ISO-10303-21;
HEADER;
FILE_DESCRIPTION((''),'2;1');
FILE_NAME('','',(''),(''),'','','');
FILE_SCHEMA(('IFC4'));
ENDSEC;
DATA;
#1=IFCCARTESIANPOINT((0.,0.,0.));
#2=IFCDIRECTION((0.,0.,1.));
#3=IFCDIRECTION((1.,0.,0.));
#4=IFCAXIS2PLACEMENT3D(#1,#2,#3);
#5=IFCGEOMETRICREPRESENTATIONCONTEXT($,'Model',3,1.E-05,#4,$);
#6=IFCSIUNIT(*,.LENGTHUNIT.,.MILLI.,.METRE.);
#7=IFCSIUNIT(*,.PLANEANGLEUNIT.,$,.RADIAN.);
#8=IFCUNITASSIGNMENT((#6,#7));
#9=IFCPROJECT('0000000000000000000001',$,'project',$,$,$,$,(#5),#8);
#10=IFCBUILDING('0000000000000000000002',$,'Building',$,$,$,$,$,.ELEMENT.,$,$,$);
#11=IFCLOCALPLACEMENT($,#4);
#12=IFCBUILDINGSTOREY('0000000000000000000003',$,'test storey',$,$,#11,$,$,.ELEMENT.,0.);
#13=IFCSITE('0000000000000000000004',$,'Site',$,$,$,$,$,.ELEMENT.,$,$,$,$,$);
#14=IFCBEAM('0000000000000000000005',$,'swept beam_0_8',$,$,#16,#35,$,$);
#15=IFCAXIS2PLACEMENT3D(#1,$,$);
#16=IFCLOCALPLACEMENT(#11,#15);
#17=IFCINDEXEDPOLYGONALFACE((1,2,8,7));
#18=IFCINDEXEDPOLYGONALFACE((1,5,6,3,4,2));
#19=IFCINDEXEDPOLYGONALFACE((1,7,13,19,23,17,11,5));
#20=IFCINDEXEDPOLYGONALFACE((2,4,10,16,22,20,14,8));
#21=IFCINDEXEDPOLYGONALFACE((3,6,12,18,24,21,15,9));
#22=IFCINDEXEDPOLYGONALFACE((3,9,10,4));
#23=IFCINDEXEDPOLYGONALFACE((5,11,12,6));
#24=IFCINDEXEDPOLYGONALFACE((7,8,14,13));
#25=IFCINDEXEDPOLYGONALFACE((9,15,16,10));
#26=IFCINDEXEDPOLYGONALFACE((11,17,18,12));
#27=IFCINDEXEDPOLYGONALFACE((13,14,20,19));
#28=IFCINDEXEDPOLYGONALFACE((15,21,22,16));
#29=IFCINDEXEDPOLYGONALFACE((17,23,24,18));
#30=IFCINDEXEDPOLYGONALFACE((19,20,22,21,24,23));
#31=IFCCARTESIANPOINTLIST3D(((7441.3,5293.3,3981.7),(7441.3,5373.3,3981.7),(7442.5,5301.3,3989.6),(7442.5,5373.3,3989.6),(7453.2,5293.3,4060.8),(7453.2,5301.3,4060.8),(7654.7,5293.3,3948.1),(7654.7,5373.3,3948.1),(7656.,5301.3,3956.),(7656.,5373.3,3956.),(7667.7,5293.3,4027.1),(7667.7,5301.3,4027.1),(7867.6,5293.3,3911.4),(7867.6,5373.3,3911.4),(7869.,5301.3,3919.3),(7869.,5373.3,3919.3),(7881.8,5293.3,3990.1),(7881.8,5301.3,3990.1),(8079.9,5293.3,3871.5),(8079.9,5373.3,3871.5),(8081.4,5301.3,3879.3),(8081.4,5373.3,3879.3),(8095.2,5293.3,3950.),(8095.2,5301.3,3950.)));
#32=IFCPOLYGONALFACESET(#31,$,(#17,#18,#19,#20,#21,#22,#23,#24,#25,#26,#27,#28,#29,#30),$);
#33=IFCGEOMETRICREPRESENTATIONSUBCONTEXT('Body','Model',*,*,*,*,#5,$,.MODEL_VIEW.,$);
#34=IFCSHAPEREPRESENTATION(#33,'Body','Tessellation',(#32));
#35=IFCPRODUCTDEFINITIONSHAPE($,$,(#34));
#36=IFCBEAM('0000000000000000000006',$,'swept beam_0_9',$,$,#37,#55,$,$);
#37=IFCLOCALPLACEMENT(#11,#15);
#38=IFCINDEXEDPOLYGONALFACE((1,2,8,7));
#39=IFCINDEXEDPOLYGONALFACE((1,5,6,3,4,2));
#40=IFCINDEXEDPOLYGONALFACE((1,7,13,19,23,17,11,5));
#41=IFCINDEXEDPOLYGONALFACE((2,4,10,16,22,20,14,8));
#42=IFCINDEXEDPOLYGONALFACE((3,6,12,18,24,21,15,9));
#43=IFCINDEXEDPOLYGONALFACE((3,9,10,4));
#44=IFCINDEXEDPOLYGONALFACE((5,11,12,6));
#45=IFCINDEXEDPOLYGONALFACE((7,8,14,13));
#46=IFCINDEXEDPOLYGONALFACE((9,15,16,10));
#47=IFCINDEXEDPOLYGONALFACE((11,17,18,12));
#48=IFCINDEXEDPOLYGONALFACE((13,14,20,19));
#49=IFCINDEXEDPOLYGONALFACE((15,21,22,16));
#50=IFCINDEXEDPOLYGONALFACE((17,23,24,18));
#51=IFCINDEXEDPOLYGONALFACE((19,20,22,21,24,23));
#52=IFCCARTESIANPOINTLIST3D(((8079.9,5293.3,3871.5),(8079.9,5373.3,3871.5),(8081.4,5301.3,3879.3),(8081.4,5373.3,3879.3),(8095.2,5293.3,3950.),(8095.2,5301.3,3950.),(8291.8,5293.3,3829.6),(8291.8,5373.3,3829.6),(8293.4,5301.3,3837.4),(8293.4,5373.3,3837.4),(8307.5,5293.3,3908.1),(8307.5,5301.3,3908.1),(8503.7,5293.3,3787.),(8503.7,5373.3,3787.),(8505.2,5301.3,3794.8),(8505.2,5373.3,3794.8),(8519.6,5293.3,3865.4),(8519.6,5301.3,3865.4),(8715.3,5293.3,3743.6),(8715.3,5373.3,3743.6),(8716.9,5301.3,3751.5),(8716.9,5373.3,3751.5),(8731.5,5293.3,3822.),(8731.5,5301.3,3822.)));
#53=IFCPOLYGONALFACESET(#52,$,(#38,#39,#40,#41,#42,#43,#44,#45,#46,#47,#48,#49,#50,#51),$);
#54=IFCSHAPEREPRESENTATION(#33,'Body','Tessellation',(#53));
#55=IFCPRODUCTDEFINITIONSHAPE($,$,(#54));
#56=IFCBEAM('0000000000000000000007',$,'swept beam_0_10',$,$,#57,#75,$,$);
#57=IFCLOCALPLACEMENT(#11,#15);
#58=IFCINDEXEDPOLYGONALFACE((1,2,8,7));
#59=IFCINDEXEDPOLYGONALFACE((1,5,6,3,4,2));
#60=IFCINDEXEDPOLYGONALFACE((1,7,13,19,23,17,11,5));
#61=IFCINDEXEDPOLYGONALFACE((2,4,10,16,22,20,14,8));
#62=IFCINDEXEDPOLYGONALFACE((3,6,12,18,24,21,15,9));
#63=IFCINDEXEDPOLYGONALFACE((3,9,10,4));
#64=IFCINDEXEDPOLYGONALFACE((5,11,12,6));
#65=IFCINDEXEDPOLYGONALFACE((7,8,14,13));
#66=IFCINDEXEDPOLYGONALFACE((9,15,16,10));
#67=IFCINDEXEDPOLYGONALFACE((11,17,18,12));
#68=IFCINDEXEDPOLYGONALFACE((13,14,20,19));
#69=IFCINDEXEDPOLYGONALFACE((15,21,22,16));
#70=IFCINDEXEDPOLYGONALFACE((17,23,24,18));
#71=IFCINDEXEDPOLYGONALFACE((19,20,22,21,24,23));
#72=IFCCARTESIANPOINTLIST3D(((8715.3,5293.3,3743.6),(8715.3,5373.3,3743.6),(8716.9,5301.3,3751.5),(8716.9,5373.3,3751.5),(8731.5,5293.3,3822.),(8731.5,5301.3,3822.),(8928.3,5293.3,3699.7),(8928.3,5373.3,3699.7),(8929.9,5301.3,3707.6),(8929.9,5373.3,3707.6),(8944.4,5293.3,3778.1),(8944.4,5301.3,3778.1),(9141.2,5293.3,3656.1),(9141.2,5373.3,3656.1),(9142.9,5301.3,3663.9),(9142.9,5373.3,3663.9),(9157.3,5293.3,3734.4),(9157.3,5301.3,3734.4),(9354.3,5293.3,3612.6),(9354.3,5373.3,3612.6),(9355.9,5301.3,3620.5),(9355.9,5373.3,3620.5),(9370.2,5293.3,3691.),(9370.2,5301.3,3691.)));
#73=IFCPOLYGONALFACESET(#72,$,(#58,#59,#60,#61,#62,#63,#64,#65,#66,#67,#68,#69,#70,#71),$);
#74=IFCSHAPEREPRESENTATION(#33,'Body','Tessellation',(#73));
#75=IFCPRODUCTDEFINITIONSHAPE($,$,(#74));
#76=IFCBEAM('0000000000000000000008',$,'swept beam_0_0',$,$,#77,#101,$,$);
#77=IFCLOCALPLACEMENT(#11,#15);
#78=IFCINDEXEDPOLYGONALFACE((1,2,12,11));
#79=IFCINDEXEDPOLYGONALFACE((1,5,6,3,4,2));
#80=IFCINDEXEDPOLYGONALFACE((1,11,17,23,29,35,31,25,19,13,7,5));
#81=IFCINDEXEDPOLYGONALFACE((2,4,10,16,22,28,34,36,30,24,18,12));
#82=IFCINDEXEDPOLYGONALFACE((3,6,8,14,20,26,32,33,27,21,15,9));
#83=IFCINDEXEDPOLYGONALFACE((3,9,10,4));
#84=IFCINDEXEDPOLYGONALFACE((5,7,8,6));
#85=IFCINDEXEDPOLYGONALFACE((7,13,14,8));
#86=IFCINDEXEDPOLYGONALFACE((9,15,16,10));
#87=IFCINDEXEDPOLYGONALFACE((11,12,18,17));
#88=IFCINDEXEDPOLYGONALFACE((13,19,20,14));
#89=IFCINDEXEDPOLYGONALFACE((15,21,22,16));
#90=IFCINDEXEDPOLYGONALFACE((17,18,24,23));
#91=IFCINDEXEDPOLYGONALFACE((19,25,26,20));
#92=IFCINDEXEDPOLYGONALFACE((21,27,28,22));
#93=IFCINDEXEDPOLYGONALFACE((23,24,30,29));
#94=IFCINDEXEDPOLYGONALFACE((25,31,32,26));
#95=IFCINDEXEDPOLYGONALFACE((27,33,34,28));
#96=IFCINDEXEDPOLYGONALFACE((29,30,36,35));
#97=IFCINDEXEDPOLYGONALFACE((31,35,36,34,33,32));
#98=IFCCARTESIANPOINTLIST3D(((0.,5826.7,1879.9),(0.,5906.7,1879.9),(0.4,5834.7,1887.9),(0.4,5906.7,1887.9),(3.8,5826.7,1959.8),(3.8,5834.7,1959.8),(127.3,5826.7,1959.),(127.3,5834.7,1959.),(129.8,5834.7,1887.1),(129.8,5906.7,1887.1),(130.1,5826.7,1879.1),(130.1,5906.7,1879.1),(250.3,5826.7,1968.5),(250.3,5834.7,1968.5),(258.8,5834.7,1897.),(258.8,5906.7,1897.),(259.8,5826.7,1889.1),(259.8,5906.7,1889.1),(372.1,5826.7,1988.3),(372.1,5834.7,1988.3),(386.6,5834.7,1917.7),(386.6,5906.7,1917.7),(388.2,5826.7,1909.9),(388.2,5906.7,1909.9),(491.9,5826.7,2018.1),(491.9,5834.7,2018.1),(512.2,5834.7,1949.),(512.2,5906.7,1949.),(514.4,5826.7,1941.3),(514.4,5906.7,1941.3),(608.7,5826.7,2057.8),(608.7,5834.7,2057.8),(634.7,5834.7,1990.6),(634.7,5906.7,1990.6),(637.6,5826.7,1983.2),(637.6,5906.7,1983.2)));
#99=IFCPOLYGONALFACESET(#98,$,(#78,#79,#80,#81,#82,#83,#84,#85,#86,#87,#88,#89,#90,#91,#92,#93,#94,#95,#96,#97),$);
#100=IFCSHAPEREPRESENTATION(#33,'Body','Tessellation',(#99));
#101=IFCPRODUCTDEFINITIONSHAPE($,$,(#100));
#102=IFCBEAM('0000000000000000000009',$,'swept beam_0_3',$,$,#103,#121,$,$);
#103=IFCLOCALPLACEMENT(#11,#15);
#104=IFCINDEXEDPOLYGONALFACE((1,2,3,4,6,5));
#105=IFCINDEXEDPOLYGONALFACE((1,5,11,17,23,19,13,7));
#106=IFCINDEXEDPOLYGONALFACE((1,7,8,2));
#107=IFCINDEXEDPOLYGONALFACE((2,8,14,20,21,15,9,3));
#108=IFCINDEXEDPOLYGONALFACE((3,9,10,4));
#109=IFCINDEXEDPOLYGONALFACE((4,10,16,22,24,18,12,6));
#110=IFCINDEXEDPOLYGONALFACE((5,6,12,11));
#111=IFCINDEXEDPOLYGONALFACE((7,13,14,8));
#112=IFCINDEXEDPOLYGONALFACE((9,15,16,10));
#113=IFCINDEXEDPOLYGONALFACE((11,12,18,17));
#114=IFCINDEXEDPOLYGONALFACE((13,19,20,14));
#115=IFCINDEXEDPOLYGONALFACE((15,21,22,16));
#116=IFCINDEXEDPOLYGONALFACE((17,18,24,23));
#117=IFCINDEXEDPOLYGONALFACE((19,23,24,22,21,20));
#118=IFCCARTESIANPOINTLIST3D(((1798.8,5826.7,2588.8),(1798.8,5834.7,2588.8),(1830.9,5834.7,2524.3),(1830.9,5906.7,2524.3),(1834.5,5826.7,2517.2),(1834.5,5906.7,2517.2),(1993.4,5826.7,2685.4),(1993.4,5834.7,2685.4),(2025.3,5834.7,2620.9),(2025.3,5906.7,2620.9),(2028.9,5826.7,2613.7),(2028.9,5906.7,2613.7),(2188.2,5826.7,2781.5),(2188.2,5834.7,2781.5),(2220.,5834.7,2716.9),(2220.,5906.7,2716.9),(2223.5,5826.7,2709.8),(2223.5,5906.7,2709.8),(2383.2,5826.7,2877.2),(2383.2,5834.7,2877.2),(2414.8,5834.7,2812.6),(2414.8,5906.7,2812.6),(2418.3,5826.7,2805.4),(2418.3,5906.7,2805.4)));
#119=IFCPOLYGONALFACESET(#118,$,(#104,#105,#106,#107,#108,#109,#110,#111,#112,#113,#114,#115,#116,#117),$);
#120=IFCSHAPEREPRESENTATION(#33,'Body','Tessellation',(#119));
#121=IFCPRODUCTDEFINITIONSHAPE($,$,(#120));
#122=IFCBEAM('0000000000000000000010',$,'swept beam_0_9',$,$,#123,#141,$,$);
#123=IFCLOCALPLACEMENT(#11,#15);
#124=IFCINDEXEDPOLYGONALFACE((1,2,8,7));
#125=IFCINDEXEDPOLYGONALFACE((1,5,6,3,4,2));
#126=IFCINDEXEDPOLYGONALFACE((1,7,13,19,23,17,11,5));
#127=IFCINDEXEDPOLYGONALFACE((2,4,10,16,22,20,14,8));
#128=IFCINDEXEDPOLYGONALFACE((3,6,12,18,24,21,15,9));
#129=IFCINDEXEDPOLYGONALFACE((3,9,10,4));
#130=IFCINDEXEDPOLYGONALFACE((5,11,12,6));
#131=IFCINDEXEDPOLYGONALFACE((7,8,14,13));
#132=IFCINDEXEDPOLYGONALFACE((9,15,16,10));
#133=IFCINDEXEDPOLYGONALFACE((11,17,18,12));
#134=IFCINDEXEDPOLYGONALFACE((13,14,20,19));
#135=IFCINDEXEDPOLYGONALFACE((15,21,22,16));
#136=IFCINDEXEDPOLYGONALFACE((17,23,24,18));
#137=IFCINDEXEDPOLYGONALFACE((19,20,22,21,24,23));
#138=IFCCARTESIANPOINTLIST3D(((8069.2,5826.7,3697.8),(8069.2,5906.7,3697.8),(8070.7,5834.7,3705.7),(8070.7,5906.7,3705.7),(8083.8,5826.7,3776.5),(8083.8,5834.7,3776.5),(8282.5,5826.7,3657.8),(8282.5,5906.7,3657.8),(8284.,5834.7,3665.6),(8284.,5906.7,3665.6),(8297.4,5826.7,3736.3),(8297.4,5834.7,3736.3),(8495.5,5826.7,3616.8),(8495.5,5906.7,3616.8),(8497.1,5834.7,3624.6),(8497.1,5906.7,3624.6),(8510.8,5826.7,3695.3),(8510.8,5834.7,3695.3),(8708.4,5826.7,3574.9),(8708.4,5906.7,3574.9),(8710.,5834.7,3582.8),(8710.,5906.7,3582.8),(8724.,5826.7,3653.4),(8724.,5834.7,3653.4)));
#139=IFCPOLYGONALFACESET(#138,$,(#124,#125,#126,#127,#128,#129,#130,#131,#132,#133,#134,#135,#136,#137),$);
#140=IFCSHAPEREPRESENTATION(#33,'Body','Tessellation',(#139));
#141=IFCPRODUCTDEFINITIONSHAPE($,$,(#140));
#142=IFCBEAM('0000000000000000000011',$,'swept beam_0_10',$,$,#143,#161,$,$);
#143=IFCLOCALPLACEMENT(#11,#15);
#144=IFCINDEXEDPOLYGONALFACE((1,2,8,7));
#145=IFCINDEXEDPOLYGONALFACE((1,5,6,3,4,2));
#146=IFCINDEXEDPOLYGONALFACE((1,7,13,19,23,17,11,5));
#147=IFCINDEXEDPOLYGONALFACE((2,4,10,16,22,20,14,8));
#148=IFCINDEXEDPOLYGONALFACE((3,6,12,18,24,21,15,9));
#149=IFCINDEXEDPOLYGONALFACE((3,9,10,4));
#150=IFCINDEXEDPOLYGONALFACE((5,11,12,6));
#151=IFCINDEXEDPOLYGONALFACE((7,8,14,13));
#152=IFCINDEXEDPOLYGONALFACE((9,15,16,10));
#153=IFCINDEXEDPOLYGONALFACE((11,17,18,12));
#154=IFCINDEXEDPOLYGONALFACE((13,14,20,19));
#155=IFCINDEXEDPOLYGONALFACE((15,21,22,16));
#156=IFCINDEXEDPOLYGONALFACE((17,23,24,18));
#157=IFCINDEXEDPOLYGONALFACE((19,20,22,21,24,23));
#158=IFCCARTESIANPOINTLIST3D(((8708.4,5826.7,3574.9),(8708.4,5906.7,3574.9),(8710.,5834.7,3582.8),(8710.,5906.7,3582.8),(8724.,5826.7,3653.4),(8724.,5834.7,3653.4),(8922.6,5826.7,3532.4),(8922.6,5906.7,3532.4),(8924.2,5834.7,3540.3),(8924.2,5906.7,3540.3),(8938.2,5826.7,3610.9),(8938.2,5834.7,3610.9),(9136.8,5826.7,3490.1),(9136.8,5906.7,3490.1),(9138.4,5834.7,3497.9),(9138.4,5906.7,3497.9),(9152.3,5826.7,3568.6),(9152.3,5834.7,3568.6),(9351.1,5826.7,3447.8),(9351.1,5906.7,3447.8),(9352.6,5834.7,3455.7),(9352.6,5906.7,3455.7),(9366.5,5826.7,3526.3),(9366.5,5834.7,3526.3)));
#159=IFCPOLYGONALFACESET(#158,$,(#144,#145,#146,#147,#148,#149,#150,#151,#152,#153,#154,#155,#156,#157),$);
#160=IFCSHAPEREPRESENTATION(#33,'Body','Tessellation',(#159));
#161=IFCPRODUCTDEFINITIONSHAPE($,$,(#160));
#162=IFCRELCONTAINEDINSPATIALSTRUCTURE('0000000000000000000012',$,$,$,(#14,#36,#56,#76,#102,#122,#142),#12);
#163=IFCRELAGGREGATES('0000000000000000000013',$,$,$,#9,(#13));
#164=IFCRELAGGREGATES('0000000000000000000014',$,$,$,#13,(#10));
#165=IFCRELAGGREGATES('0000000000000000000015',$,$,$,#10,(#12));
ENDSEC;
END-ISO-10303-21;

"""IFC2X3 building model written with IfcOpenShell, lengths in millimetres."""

from ifc_helpers import new_model, entity, si_unit, origin_with_axes, place, context, subcontext, project, spatial, element, save


model = new_model("IFC2X3")

# Units and contexts
model_context = context("Model", 3, precision=1e-05, world=origin_with_axes())
body_context = subcontext(model_context, "Body", "Model", "MODEL_VIEW")
ifc_project = project(units=[si_unit("LENGTHUNIT", "METRE", prefix="MILLI"), si_unit("PLANEANGLEUNIT", "RADIAN")], contexts=[model_context])

# Site, building, storey
site = spatial("IfcSite", under=ifc_project, Name="Site", CompositionType="ELEMENT")
building = spatial("IfcBuilding", under=site, Name="Building", CompositionType="ELEMENT")
storey_placement = place(None, origin_with_axes())
storey = spatial("IfcBuildingStorey", under=building, at=storey_placement, Name="test storey", CompositionType="ELEMENT", Elevation=0.0)

# Beams
beam_1_placement = place(storey_placement, origin_with_axes())
element("IfcBeam", 1, at=beam_1_placement, inside=storey, Name="swept beam_0_8", context=body_context, shape_type="SweptSolid", body=[
    entity("IfcRevolvedAreaSolid", entity("IfcArbitraryClosedProfileDef", "AREA", None, entity("IfcPolyline", [entity("IfcCartesianPoint", [80.0, -40.0]), entity("IfcCartesianPoint", [80.0, -32.0]), entity("IfcCartesianPoint", [8.0, -32.0]), entity("IfcCartesianPoint", [8.0, 40.0]), entity("IfcCartesianPoint", [0.0, 40.0]), entity("IfcCartesianPoint", [0.0, -40.0]), entity("IfcCartesianPoint", [80.0, -40.0])])), entity("IfcAxis2Placement3D", entity("IfcCartesianPoint", [7441.3, 5333.3, 3981.7]), entity("IfcDirection", [-0.989, 0.0, 0.1481]), entity("IfcDirection", [0.1481, 0.0, 0.989])), entity("IfcAxis1Placement", entity("IfcCartesianPoint", [-14553.3, 0.0, 0.0]), entity("IfcDirection", [0.0, 1.0, 0.0])), 0.044531),
])
beam_2_placement = place(storey_placement, origin_with_axes())
element("IfcBeam", 2, at=beam_2_placement, inside=storey, Name="swept beam_0_9", context=body_context, shape_type="SweptSolid", body=[
    entity("IfcRevolvedAreaSolid", entity("IfcArbitraryClosedProfileDef", "AREA", None, entity("IfcPolyline", [entity("IfcCartesianPoint", [80.0, -40.0]), entity("IfcCartesianPoint", [80.0, -32.0]), entity("IfcCartesianPoint", [8.0, -32.0]), entity("IfcCartesianPoint", [8.0, 40.0]), entity("IfcCartesianPoint", [0.0, 40.0]), entity("IfcCartesianPoint", [0.0, -40.0]), entity("IfcCartesianPoint", [80.0, -40.0])])), entity("IfcAxis2Placement3D", entity("IfcCartesianPoint", [8079.9, 5333.3, 3871.5]), entity("IfcDirection", [-0.9814, 0.0, 0.192]), entity("IfcDirection", [0.192, 0.0, 0.9814])), entity("IfcAxis1Placement", entity("IfcCartesianPoint", [-61071.2, 0.0, 0.0]), entity("IfcDirection", [0.0, 1.0, 0.0])), 0.010613),
])
beam_3_placement = place(storey_placement, origin_with_axes())
element("IfcBeam", 3, at=beam_3_placement, inside=storey, Name="swept beam_0_10", context=body_context, shape_type="SweptSolid", body=[
    entity("IfcRevolvedAreaSolid", entity("IfcArbitraryClosedProfileDef", "AREA", None, entity("IfcPolyline", [entity("IfcCartesianPoint", [-80.0, 40.0]), entity("IfcCartesianPoint", [-80.0, 32.0]), entity("IfcCartesianPoint", [-8.0, 32.0]), entity("IfcCartesianPoint", [-8.0, -40.0]), entity("IfcCartesianPoint", [0.0, -40.0]), entity("IfcCartesianPoint", [0.0, 40.0]), entity("IfcCartesianPoint", [-80.0, 40.0])])), entity("IfcAxis2Placement3D", entity("IfcCartesianPoint", [8715.3, 5333.3, 3743.6]), entity("IfcDirection", [-0.9793, 0.0, 0.2024]), entity("IfcDirection", [-0.2024, 0.0, -0.9793])), entity("IfcAxis1Placement", entity("IfcCartesianPoint", [-205416.2, 0.0, 0.0]), entity("IfcDirection", [0.0, 1.0, 0.0])), 0.003175),
])
beam_4_placement = place(storey_placement, origin_with_axes())
element("IfcBeam", 4, at=beam_4_placement, inside=storey, Name="swept beam_0_0", context=body_context, shape_type="SweptSolid", body=[
    entity("IfcRevolvedAreaSolid", entity("IfcArbitraryClosedProfileDef", "AREA", None, entity("IfcPolyline", [entity("IfcCartesianPoint", [-80.0, 40.0]), entity("IfcCartesianPoint", [-80.0, 32.0]), entity("IfcCartesianPoint", [-8.0, 32.0]), entity("IfcCartesianPoint", [-8.0, -40.0]), entity("IfcCartesianPoint", [0.0, -40.0]), entity("IfcCartesianPoint", [0.0, 40.0]), entity("IfcCartesianPoint", [-80.0, 40.0])])), entity("IfcAxis2Placement3D", entity("IfcCartesianPoint", [0.0, 5866.7, 1879.9]), entity("IfcDirection", [-0.9988, 0.0, 0.0481]), entity("IfcDirection", [-0.0481, 0.0, -0.9988])), entity("IfcAxis1Placement", entity("IfcCartesianPoint", [-1559.0, 0.0, 0.0]), entity("IfcDirection", [0.0, 1.0, 0.0])), 0.417349),
])
beam_5_placement = place(storey_placement, origin_with_axes())
element("IfcBeam", 5, at=beam_5_placement, inside=storey, Name="swept beam_0_3", context=body_context, shape_type="SweptSolid", body=[
    entity("IfcRevolvedAreaSolid", entity("IfcArbitraryClosedProfileDef", "AREA", None, entity("IfcPolyline", [entity("IfcCartesianPoint", [80.0, -40.0]), entity("IfcCartesianPoint", [80.0, -32.0]), entity("IfcCartesianPoint", [8.0, -32.0]), entity("IfcCartesianPoint", [8.0, 40.0]), entity("IfcCartesianPoint", [0.0, 40.0]), entity("IfcCartesianPoint", [0.0, -40.0]), entity("IfcCartesianPoint", [80.0, -40.0])])), entity("IfcAxis2Placement3D", entity("IfcCartesianPoint", [1834.5, 5866.7, 2517.2]), entity("IfcDirection", [-0.8951, 0.0, -0.4458]), entity("IfcDirection", [-0.4458, 0.0, 0.8951])), entity("IfcAxis1Placement", entity("IfcCartesianPoint", [-93401.1, 0.0, 0.0]), entity("IfcDirection", [0.0, 1.0, 0.0])), 0.006971),
])
beam_6_placement = place(storey_placement, origin_with_axes())
element("IfcBeam", 6, at=beam_6_placement, inside=storey, Name="swept beam_0_9", context=body_context, shape_type="SweptSolid", body=[
    entity("IfcRevolvedAreaSolid", entity("IfcArbitraryClosedProfileDef", "AREA", None, entity("IfcPolyline", [entity("IfcCartesianPoint", [80.0, -40.0]), entity("IfcCartesianPoint", [80.0, -32.0]), entity("IfcCartesianPoint", [8.0, -32.0]), entity("IfcCartesianPoint", [8.0, 40.0]), entity("IfcCartesianPoint", [0.0, 40.0]), entity("IfcCartesianPoint", [0.0, -40.0]), entity("IfcCartesianPoint", [80.0, -40.0])])), entity("IfcAxis2Placement3D", entity("IfcCartesianPoint", [8069.2, 5866.7, 3697.8]), entity("IfcDirection", [-0.9832, 0.0, 0.1827]), entity("IfcDirection", [0.1827, 0.0, 0.9832])), entity("IfcAxis1Placement", entity("IfcCartesianPoint", [-52365.9, 0.0, 0.0]), entity("IfcDirection", [0.0, 1.0, 0.0])), 0.012431),
])
beam_7_placement = place(storey_placement, origin_with_axes())
element("IfcBeam", 7, at=beam_7_placement, inside=storey, Name="swept beam_0_10", context=body_context, shape_type="SweptSolid", body=[
    entity("IfcRevolvedAreaSolid", entity("IfcArbitraryClosedProfileDef", "AREA", None, entity("IfcPolyline", [entity("IfcCartesianPoint", [-80.0, 40.0]), entity("IfcCartesianPoint", [-80.0, 32.0]), entity("IfcCartesianPoint", [-8.0, 32.0]), entity("IfcCartesianPoint", [-8.0, -40.0]), entity("IfcCartesianPoint", [0.0, -40.0]), entity("IfcCartesianPoint", [0.0, 40.0]), entity("IfcCartesianPoint", [-80.0, 40.0])])), entity("IfcAxis2Placement3D", entity("IfcCartesianPoint", [8708.4, 5866.7, 3574.9]), entity("IfcDirection", [-0.9808, 0.0, 0.1949]), entity("IfcDirection", [-0.1949, 0.0, -0.9808])), entity("IfcAxis1Placement", entity("IfcCartesianPoint", [-385536.9, 0.0, 0.0]), entity("IfcDirection", [0.0, 1.0, 0.0])), 0.001699),
])

save(model, "model.ifc")
